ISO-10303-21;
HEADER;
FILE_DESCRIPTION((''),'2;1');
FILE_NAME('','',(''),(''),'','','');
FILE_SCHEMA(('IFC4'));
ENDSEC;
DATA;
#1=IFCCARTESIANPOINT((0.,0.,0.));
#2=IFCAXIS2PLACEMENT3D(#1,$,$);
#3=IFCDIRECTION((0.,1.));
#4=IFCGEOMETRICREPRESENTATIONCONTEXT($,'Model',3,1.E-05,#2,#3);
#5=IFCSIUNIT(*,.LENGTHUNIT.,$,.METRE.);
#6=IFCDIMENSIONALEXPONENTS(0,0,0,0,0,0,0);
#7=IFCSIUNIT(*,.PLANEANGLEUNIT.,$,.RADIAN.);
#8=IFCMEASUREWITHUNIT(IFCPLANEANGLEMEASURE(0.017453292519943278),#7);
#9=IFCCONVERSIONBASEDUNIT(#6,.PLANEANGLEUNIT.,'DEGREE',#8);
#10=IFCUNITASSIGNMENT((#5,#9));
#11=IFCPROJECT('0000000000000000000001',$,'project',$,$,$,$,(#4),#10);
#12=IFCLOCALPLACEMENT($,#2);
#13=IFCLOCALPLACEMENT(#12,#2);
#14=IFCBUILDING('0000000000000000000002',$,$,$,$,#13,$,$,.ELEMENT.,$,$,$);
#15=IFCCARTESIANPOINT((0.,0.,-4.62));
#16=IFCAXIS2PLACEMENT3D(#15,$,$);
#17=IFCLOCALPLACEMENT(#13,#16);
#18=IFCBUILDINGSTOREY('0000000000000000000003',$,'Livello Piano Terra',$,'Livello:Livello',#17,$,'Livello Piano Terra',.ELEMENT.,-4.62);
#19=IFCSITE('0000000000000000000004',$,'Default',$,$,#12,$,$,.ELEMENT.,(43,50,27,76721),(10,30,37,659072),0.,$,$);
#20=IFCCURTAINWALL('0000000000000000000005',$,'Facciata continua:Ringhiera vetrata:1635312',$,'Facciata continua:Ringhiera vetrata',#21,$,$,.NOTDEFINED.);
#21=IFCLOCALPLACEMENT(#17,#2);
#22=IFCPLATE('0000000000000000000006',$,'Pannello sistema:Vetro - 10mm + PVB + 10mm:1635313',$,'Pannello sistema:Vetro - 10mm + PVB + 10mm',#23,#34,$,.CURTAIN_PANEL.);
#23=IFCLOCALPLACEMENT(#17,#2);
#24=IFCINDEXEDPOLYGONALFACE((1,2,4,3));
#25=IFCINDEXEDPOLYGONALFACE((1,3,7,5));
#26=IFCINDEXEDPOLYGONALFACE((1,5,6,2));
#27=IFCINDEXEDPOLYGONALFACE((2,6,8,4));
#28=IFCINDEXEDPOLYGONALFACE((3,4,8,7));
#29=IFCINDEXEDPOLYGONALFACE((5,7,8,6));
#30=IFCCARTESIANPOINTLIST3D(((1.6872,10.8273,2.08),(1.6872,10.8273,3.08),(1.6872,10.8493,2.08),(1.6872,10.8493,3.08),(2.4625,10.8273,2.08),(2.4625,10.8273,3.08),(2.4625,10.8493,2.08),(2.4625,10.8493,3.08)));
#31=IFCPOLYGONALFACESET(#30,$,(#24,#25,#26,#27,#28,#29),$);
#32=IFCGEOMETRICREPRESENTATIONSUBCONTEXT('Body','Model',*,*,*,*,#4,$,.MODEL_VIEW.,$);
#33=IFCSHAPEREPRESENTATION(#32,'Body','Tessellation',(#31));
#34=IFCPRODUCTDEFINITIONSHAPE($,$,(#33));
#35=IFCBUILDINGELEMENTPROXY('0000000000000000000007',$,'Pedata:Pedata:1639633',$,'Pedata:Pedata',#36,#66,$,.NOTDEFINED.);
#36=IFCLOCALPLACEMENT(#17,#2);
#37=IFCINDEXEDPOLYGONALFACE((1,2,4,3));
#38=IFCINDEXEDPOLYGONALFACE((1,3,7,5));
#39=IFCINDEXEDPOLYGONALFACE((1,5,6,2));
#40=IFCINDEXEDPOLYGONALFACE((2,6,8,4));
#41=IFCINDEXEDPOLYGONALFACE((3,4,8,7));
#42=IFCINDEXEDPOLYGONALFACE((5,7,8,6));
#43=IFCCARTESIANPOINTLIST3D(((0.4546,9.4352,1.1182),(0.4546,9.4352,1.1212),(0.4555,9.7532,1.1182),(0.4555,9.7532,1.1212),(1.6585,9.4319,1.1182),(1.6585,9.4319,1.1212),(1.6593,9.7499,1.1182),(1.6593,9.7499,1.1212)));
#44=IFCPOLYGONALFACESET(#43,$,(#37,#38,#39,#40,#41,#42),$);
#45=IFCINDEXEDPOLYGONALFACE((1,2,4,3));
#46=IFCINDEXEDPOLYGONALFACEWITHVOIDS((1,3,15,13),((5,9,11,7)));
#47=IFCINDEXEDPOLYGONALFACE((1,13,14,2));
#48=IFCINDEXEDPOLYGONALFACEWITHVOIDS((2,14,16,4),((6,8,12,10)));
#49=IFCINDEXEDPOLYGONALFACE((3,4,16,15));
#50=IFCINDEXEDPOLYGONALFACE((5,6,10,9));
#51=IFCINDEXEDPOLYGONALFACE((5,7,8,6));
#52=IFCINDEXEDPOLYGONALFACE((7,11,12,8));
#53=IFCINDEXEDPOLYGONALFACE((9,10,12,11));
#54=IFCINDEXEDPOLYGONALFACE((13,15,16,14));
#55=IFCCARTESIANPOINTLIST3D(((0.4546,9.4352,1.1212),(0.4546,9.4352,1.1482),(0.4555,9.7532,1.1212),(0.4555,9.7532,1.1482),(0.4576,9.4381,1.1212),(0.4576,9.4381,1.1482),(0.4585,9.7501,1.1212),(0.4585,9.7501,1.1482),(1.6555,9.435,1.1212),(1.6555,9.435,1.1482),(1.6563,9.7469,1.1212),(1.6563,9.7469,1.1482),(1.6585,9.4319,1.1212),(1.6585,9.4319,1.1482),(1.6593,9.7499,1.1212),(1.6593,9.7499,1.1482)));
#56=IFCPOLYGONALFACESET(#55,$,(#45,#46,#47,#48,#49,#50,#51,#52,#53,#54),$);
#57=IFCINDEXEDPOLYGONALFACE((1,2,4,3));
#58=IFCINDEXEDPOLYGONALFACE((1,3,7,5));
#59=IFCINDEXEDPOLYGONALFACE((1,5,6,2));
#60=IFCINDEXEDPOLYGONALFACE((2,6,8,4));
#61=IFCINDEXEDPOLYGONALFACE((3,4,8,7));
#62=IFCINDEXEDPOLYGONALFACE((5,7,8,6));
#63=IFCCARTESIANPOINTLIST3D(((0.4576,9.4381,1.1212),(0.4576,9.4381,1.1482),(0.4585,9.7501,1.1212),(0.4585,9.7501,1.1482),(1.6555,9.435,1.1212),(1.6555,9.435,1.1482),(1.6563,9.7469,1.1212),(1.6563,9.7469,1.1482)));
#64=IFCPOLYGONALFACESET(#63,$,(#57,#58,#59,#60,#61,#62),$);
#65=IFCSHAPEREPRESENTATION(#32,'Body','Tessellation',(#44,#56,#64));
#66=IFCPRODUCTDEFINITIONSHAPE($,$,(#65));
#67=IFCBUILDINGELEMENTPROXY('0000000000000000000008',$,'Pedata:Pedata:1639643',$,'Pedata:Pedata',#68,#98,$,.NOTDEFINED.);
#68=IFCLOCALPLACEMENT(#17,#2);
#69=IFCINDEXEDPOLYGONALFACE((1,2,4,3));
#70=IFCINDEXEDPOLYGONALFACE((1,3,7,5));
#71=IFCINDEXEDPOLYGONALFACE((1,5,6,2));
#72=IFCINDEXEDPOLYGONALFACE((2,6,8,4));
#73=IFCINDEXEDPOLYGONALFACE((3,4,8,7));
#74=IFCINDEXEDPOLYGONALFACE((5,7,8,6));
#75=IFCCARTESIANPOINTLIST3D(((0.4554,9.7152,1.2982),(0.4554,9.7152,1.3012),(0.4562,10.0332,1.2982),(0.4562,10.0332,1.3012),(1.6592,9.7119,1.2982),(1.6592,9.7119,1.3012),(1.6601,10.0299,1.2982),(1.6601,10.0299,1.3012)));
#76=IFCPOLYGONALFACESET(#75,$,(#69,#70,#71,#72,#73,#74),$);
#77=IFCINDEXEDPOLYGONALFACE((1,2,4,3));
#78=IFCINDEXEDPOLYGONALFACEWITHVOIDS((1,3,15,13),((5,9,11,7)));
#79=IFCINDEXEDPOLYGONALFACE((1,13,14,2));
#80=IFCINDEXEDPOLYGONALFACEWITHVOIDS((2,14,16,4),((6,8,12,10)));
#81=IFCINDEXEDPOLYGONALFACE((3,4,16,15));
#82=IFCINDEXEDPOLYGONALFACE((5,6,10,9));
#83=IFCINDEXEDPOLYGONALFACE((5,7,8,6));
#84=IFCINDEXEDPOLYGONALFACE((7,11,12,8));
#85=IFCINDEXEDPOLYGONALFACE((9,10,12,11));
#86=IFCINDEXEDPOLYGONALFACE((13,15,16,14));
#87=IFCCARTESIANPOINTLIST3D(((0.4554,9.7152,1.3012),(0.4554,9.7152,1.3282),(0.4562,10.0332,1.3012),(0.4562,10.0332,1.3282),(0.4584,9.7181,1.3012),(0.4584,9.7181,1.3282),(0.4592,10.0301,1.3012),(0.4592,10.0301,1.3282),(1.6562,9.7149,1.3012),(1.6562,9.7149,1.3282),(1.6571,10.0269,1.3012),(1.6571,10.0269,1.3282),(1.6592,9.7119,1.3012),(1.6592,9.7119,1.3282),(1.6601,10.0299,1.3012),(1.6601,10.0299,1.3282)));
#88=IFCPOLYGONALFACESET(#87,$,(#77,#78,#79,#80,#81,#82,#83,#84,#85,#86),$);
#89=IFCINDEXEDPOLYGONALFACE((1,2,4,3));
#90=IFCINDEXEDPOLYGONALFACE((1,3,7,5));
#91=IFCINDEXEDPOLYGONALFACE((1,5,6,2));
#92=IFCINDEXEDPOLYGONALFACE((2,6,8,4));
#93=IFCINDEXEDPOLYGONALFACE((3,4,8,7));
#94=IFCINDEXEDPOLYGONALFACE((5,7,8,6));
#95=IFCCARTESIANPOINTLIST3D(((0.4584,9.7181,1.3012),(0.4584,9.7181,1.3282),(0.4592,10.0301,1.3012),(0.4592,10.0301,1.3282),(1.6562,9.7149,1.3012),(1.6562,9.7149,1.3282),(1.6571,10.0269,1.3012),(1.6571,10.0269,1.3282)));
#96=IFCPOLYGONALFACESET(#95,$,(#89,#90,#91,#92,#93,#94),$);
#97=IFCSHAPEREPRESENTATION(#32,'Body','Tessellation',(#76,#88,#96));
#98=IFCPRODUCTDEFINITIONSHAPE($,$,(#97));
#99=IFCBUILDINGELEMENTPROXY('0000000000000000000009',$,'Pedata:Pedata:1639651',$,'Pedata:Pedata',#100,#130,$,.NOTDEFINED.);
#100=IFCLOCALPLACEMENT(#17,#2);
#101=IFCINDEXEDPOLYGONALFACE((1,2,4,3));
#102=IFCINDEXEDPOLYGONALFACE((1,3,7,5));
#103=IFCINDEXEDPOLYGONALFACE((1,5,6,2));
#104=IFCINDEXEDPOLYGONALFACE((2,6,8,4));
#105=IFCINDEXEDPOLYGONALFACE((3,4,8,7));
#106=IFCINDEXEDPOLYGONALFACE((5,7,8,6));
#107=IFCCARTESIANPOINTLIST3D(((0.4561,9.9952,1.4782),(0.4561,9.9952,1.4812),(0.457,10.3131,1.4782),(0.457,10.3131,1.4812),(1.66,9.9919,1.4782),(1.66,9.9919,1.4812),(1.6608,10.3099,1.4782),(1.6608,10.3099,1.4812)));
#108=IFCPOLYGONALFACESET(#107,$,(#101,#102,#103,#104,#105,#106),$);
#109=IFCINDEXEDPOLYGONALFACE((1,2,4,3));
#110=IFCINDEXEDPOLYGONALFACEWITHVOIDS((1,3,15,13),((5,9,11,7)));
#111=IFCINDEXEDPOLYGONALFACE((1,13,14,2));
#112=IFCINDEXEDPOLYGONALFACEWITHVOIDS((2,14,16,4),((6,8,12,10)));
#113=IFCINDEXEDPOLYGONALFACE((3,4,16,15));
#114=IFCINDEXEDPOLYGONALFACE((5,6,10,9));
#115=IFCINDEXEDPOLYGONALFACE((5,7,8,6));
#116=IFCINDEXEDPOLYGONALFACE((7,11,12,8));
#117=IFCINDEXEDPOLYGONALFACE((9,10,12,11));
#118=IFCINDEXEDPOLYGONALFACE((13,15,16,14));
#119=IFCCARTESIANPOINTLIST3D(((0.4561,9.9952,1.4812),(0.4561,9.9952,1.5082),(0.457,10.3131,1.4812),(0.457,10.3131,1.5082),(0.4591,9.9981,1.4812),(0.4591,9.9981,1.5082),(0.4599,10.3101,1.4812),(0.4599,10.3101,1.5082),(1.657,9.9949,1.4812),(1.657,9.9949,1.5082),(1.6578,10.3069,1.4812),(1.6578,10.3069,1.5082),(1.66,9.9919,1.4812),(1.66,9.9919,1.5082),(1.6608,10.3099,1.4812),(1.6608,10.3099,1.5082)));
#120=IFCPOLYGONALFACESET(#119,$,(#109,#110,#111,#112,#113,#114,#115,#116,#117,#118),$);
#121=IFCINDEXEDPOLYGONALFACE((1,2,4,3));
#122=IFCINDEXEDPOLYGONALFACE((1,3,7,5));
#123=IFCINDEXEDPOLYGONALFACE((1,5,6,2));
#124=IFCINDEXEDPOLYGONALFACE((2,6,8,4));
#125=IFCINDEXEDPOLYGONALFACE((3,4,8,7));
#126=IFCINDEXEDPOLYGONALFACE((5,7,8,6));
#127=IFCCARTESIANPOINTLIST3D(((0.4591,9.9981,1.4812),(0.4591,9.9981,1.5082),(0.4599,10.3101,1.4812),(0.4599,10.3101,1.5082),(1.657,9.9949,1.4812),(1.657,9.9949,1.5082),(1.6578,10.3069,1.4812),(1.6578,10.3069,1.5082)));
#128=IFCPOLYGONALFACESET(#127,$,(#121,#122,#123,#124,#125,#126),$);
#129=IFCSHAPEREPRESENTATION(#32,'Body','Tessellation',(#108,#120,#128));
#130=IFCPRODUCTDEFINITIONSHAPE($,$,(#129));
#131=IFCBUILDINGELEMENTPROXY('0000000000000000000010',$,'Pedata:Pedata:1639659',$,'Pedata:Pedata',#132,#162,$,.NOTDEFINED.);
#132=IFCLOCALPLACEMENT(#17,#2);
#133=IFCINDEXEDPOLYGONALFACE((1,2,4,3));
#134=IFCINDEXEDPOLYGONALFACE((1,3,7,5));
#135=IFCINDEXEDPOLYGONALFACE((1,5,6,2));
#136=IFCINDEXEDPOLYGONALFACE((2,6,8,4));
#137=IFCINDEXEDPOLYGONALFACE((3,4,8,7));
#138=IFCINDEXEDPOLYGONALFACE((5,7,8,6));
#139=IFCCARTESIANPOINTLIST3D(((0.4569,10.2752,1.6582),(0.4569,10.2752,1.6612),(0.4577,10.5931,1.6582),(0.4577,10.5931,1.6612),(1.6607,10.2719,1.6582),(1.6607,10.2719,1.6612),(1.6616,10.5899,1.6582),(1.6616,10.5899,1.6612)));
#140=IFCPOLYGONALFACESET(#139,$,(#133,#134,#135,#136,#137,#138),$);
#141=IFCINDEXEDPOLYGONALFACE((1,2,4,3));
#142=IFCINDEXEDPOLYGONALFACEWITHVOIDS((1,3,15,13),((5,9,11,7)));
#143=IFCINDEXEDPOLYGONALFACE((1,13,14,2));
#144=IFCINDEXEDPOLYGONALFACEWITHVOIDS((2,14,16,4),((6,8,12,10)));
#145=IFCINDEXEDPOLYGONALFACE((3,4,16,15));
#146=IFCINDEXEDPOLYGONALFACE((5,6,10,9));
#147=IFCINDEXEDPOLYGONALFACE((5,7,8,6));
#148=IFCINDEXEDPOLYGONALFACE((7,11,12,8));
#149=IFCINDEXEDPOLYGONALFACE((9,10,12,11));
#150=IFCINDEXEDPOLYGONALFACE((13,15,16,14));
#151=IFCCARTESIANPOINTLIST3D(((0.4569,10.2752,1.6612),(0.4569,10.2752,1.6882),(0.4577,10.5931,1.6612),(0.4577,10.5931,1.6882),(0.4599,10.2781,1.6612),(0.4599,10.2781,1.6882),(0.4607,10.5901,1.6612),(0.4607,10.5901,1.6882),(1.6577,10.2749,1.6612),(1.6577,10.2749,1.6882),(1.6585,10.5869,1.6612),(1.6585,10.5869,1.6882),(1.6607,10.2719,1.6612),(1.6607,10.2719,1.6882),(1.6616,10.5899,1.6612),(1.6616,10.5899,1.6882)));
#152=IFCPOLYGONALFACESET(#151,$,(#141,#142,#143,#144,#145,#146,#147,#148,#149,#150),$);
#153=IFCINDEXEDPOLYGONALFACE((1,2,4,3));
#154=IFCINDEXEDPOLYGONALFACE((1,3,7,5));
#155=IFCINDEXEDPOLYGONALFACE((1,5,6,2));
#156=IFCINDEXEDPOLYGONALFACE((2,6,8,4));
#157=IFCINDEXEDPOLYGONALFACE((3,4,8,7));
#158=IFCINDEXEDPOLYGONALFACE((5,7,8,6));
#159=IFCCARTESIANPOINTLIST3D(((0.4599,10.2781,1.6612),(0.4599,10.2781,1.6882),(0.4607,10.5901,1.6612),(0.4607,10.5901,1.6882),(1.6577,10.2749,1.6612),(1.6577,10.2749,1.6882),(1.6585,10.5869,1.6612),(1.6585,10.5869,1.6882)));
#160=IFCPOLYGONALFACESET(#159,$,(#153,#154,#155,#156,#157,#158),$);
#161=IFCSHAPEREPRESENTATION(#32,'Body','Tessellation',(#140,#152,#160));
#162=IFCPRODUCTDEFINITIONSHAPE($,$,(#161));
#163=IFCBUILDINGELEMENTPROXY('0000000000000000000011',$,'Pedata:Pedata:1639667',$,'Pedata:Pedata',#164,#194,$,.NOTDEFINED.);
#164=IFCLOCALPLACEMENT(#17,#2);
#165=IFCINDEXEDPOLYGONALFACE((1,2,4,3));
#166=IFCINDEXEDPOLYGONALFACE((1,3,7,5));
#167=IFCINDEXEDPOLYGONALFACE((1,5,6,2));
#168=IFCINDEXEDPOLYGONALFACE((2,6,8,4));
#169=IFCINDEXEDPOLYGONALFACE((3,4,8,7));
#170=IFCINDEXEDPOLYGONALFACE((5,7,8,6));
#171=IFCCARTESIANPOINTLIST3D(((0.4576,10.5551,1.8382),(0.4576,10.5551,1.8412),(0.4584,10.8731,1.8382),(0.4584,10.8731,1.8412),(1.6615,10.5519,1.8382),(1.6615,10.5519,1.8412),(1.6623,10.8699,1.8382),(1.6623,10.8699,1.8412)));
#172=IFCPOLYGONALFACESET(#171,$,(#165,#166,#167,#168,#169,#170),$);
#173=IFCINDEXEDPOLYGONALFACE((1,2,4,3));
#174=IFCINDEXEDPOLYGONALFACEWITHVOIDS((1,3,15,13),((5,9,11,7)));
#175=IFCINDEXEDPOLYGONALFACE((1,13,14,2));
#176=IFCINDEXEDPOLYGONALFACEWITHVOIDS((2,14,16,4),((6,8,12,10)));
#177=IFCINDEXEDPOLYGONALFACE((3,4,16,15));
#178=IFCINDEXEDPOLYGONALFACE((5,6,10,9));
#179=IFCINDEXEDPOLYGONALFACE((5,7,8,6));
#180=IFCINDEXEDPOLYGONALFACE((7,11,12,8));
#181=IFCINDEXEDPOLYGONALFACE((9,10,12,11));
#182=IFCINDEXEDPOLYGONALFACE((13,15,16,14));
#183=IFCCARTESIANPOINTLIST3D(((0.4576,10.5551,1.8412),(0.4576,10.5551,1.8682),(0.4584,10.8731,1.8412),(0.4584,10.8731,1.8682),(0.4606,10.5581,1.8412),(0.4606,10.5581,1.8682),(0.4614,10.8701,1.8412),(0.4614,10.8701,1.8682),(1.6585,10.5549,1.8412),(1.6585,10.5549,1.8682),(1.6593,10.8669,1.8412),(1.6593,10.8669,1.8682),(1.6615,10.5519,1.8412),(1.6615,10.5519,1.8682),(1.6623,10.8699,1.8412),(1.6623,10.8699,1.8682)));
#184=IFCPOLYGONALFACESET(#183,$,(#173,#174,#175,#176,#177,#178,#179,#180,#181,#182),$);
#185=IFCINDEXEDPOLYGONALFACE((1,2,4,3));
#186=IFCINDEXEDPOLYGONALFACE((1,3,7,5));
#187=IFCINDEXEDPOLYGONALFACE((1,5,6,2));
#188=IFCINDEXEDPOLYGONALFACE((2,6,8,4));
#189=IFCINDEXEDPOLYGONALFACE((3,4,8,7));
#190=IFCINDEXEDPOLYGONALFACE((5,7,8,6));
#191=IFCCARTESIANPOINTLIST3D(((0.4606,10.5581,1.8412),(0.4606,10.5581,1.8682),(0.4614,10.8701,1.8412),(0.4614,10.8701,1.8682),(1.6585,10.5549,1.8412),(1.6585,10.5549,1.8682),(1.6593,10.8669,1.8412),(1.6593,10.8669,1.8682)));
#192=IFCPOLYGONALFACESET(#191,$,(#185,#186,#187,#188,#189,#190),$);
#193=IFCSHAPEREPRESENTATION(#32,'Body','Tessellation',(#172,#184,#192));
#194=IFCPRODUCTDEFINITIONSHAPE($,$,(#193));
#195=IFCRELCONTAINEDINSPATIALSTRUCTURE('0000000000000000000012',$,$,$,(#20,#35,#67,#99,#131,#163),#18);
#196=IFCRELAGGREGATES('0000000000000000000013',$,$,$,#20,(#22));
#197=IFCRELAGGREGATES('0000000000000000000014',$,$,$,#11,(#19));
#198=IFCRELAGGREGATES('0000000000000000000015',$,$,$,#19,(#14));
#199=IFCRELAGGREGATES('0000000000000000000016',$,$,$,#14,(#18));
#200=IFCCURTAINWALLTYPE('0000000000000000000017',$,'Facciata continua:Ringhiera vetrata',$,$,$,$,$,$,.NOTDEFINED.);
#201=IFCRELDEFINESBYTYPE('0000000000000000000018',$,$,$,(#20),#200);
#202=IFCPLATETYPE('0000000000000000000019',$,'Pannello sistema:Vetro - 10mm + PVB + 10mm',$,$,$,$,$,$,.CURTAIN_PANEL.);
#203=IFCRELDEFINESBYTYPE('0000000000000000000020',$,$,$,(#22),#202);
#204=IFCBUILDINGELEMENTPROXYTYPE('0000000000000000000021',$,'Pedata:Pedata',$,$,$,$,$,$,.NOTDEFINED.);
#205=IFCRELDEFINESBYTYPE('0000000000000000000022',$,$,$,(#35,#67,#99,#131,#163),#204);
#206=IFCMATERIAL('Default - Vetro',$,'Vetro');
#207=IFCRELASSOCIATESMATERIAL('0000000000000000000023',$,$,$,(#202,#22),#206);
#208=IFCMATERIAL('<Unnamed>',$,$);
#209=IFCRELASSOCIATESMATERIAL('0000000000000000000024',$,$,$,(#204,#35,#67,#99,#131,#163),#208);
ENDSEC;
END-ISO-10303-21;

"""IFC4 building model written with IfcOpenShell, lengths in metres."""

from ifc_helpers import new_model, entity, si_unit, converted_unit, direction, frame, origin, place, context, subcontext, project, spatial, indexed_curve, outline, extrude, source, transform, mapped, material, type_object, type_shapes, element, aggregate, save


model = new_model("IFC4")

# Units and contexts
model_context = context("Model", 3, precision=1e-05, world=origin(), true_north=direction((0.0, 1.0)))
body_context = subcontext(model_context, "Body", "Model", "MODEL_VIEW")
ifc_project = project(units=[si_unit("LENGTHUNIT", "METRE"), converted_unit("PLANEANGLEUNIT", "DEGREE", entity("IfcPlaneAngleMeasure", 0.017453292519943278), si_unit("PLANEANGLEUNIT", "RADIAN"), dimensions=[0, 0, 0, 0, 0, 0, 0])], contexts=[model_context])

# Site, building, storey
site_placement = place(None, origin())
site = spatial("IfcSite", under=ifc_project, at=site_placement, Name="Default", CompositionType="ELEMENT", RefLatitude=(43, 50, 27, 76721), RefLongitude=(10, 30, 37, 659072), RefElevation=0.0)
building_placement = place(site_placement, origin())
building = spatial("IfcBuilding", under=site, at=building_placement, CompositionType="ELEMENT")
storey_placement = place(building_placement, frame((0.0, 0.0, -4.62)))
storey = spatial("IfcBuildingStorey", under=building, at=storey_placement, Name="Livello Piano Terra", ObjectType="Livello:Livello", LongName="Livello Piano Terra", CompositionType="ELEMENT", Elevation=-4.62)

# Shared definitions
curtain_wall_type = type_object("IfcCurtainWallType", Name="Facciata continua:Ringhiera vetrata", PredefinedType="NOTDEFINED")
ifc_material_1 = material(Name="Default - Vetro", Category="Vetro")

# Curtain wall, plate
curtain_wall_1_placement = place(storey_placement, frame((0.0, 0.0, 4.62)))
curtain_wall_1 = element("IfcCurtainWall", 1, at=curtain_wall_1_placement, inside=storey, type_object=curtain_wall_type, Name="Facciata continua:Ringhiera vetrata:1635312", ObjectType="Facciata continua:Ringhiera vetrata", PredefinedType="NOTDEFINED")
plate_type_1 = type_object("IfcPlateType", Name="Pannello sistema:Vetro - 10mm + PVB + 10mm", PredefinedType="CURTAIN_PANEL", material=ifc_material_1)
shared_shape_1 = source(origin(), body_context, "Body", "SweptSolid", [
    extrude(outline(indexed_curve([(-0.011, -0.3876), (0.011, -0.3876), (0.011, 0.3876), (-0.011, 0.3876), (-0.011, -0.3876)], self_intersect=False)), frame((0.0, 0.0, 0.0), z_axis=(0.0, 0.0, 1.0), x_axis=(0.0, 1.0, 0.0)), (0.0, 0.0, 1.0), 1.0),
])
type_shapes(plate_type_1, [shared_shape_1])
plate_1_placement = place(curtain_wall_1_placement, frame((2.0749, 10.8383, -2.54)))
plate_1 = element("IfcPlate", 2, at=plate_1_placement, type_object=plate_type_1, material=ifc_material_1, Name="Pannello sistema:Vetro - 10mm + PVB + 10mm:1635313", ObjectType="Pannello sistema:Vetro - 10mm + PVB + 10mm", PredefinedType="CURTAIN_PANEL", context=body_context, shape_type="MappedRepresentation", body=[
    mapped(shared_shape_1, transform((0.0, 0.0, 0.0), scale=1.0)),
])
aggregate(curtain_wall_1, [plate_1])

# Building element proxies
ifc_material_2 = material(Name="<Unnamed>")
building_element_proxy_type_1 = type_object("IfcBuildingElementProxyType", Name="Pedata:Pedata", PredefinedType="NOTDEFINED", material=ifc_material_2)
shared_shape_2 = source(origin(), body_context, "Body", "SweptSolid", [
    extrude(outline(indexed_curve([(-0.6019, -0.159), (0.6019, -0.159), (0.6019, 0.159), (-0.6019, 0.159), (-0.6019, -0.159)], self_intersect=False)), frame((0.0, 0.0015, -0.03), z_axis=(0.0, 0.0, 1.0), x_axis=(-1.0, 0.0, 0.0)), (0.0, 0.0, 1.0), 0.003),
    extrude(outline(indexed_curve([(-0.159, -0.6019), (0.159, -0.6019), (0.159, 0.6019), (-0.159, 0.6019), (-0.159, -0.6019)], self_intersect=False), holes=[indexed_curve([(0.156, -0.5989), (-0.156, -0.5989), (-0.156, 0.5989), (0.156, 0.5989), (0.156, -0.5989)], self_intersect=False)]), frame((0.0, 0.0015, -0.027), z_axis=(0.0, 0.0, 1.0), x_axis=(0.0, 1.0, 0.0)), (0.0, 0.0, 1.0), 0.027),
    extrude(outline(indexed_curve([(-0.5989, -0.156), (0.5989, -0.156), (0.5989, 0.156), (-0.5989, 0.156), (-0.5989, -0.156)], self_intersect=False)), frame((0.0, 0.0015, -0.027), z_axis=(0.0, 0.0, 1.0), x_axis=(-1.0, 0.0, 0.0)), (0.0, 0.0, 1.0), 0.027),
])
type_shapes(building_element_proxy_type_1, [shared_shape_2])
for number, where, z_axis, x_axis, name in (
    (3, (1.057, 9.591, 1.1482), (0.0, 0.0, 1.0), (0.999996, -0.002667, 0.0), "Pedata:Pedata:1639633"),
    (4, (1.0577, 9.871, 1.3282), (0.0, 0.0, 1.0), (0.999996, -0.002667, 0.0), "Pedata:Pedata:1639643"),
    (5, (1.0585, 10.151, 1.5082), (0.0, 0.0, 1.0), (0.999996, -0.002667, 0.0), "Pedata:Pedata:1639651"),
    (6, (1.0592, 10.431, 1.6882), (0.0, 0.0, 1.0), (0.999996, -0.002667, 0.0), "Pedata:Pedata:1639659"),
    (7, (1.0599, 10.711, 1.8682), (0.0, 0.0, 1.0), (0.999996, -0.002667, 0.0), "Pedata:Pedata:1639667"),
):
    element("IfcBuildingElementProxy", number, at=place(storey_placement, frame(where, z_axis=z_axis, x_axis=x_axis)), inside=storey, type_object=building_element_proxy_type_1, material=ifc_material_2, Name=name, ObjectType="Pedata:Pedata", PredefinedType="NOTDEFINED", context=body_context, shape_type="MappedRepresentation", body=[
        mapped(shared_shape_2, transform((0.0, 0.0, 0.0), scale=1.0)),
    ])

save(model, "model.ifc")
